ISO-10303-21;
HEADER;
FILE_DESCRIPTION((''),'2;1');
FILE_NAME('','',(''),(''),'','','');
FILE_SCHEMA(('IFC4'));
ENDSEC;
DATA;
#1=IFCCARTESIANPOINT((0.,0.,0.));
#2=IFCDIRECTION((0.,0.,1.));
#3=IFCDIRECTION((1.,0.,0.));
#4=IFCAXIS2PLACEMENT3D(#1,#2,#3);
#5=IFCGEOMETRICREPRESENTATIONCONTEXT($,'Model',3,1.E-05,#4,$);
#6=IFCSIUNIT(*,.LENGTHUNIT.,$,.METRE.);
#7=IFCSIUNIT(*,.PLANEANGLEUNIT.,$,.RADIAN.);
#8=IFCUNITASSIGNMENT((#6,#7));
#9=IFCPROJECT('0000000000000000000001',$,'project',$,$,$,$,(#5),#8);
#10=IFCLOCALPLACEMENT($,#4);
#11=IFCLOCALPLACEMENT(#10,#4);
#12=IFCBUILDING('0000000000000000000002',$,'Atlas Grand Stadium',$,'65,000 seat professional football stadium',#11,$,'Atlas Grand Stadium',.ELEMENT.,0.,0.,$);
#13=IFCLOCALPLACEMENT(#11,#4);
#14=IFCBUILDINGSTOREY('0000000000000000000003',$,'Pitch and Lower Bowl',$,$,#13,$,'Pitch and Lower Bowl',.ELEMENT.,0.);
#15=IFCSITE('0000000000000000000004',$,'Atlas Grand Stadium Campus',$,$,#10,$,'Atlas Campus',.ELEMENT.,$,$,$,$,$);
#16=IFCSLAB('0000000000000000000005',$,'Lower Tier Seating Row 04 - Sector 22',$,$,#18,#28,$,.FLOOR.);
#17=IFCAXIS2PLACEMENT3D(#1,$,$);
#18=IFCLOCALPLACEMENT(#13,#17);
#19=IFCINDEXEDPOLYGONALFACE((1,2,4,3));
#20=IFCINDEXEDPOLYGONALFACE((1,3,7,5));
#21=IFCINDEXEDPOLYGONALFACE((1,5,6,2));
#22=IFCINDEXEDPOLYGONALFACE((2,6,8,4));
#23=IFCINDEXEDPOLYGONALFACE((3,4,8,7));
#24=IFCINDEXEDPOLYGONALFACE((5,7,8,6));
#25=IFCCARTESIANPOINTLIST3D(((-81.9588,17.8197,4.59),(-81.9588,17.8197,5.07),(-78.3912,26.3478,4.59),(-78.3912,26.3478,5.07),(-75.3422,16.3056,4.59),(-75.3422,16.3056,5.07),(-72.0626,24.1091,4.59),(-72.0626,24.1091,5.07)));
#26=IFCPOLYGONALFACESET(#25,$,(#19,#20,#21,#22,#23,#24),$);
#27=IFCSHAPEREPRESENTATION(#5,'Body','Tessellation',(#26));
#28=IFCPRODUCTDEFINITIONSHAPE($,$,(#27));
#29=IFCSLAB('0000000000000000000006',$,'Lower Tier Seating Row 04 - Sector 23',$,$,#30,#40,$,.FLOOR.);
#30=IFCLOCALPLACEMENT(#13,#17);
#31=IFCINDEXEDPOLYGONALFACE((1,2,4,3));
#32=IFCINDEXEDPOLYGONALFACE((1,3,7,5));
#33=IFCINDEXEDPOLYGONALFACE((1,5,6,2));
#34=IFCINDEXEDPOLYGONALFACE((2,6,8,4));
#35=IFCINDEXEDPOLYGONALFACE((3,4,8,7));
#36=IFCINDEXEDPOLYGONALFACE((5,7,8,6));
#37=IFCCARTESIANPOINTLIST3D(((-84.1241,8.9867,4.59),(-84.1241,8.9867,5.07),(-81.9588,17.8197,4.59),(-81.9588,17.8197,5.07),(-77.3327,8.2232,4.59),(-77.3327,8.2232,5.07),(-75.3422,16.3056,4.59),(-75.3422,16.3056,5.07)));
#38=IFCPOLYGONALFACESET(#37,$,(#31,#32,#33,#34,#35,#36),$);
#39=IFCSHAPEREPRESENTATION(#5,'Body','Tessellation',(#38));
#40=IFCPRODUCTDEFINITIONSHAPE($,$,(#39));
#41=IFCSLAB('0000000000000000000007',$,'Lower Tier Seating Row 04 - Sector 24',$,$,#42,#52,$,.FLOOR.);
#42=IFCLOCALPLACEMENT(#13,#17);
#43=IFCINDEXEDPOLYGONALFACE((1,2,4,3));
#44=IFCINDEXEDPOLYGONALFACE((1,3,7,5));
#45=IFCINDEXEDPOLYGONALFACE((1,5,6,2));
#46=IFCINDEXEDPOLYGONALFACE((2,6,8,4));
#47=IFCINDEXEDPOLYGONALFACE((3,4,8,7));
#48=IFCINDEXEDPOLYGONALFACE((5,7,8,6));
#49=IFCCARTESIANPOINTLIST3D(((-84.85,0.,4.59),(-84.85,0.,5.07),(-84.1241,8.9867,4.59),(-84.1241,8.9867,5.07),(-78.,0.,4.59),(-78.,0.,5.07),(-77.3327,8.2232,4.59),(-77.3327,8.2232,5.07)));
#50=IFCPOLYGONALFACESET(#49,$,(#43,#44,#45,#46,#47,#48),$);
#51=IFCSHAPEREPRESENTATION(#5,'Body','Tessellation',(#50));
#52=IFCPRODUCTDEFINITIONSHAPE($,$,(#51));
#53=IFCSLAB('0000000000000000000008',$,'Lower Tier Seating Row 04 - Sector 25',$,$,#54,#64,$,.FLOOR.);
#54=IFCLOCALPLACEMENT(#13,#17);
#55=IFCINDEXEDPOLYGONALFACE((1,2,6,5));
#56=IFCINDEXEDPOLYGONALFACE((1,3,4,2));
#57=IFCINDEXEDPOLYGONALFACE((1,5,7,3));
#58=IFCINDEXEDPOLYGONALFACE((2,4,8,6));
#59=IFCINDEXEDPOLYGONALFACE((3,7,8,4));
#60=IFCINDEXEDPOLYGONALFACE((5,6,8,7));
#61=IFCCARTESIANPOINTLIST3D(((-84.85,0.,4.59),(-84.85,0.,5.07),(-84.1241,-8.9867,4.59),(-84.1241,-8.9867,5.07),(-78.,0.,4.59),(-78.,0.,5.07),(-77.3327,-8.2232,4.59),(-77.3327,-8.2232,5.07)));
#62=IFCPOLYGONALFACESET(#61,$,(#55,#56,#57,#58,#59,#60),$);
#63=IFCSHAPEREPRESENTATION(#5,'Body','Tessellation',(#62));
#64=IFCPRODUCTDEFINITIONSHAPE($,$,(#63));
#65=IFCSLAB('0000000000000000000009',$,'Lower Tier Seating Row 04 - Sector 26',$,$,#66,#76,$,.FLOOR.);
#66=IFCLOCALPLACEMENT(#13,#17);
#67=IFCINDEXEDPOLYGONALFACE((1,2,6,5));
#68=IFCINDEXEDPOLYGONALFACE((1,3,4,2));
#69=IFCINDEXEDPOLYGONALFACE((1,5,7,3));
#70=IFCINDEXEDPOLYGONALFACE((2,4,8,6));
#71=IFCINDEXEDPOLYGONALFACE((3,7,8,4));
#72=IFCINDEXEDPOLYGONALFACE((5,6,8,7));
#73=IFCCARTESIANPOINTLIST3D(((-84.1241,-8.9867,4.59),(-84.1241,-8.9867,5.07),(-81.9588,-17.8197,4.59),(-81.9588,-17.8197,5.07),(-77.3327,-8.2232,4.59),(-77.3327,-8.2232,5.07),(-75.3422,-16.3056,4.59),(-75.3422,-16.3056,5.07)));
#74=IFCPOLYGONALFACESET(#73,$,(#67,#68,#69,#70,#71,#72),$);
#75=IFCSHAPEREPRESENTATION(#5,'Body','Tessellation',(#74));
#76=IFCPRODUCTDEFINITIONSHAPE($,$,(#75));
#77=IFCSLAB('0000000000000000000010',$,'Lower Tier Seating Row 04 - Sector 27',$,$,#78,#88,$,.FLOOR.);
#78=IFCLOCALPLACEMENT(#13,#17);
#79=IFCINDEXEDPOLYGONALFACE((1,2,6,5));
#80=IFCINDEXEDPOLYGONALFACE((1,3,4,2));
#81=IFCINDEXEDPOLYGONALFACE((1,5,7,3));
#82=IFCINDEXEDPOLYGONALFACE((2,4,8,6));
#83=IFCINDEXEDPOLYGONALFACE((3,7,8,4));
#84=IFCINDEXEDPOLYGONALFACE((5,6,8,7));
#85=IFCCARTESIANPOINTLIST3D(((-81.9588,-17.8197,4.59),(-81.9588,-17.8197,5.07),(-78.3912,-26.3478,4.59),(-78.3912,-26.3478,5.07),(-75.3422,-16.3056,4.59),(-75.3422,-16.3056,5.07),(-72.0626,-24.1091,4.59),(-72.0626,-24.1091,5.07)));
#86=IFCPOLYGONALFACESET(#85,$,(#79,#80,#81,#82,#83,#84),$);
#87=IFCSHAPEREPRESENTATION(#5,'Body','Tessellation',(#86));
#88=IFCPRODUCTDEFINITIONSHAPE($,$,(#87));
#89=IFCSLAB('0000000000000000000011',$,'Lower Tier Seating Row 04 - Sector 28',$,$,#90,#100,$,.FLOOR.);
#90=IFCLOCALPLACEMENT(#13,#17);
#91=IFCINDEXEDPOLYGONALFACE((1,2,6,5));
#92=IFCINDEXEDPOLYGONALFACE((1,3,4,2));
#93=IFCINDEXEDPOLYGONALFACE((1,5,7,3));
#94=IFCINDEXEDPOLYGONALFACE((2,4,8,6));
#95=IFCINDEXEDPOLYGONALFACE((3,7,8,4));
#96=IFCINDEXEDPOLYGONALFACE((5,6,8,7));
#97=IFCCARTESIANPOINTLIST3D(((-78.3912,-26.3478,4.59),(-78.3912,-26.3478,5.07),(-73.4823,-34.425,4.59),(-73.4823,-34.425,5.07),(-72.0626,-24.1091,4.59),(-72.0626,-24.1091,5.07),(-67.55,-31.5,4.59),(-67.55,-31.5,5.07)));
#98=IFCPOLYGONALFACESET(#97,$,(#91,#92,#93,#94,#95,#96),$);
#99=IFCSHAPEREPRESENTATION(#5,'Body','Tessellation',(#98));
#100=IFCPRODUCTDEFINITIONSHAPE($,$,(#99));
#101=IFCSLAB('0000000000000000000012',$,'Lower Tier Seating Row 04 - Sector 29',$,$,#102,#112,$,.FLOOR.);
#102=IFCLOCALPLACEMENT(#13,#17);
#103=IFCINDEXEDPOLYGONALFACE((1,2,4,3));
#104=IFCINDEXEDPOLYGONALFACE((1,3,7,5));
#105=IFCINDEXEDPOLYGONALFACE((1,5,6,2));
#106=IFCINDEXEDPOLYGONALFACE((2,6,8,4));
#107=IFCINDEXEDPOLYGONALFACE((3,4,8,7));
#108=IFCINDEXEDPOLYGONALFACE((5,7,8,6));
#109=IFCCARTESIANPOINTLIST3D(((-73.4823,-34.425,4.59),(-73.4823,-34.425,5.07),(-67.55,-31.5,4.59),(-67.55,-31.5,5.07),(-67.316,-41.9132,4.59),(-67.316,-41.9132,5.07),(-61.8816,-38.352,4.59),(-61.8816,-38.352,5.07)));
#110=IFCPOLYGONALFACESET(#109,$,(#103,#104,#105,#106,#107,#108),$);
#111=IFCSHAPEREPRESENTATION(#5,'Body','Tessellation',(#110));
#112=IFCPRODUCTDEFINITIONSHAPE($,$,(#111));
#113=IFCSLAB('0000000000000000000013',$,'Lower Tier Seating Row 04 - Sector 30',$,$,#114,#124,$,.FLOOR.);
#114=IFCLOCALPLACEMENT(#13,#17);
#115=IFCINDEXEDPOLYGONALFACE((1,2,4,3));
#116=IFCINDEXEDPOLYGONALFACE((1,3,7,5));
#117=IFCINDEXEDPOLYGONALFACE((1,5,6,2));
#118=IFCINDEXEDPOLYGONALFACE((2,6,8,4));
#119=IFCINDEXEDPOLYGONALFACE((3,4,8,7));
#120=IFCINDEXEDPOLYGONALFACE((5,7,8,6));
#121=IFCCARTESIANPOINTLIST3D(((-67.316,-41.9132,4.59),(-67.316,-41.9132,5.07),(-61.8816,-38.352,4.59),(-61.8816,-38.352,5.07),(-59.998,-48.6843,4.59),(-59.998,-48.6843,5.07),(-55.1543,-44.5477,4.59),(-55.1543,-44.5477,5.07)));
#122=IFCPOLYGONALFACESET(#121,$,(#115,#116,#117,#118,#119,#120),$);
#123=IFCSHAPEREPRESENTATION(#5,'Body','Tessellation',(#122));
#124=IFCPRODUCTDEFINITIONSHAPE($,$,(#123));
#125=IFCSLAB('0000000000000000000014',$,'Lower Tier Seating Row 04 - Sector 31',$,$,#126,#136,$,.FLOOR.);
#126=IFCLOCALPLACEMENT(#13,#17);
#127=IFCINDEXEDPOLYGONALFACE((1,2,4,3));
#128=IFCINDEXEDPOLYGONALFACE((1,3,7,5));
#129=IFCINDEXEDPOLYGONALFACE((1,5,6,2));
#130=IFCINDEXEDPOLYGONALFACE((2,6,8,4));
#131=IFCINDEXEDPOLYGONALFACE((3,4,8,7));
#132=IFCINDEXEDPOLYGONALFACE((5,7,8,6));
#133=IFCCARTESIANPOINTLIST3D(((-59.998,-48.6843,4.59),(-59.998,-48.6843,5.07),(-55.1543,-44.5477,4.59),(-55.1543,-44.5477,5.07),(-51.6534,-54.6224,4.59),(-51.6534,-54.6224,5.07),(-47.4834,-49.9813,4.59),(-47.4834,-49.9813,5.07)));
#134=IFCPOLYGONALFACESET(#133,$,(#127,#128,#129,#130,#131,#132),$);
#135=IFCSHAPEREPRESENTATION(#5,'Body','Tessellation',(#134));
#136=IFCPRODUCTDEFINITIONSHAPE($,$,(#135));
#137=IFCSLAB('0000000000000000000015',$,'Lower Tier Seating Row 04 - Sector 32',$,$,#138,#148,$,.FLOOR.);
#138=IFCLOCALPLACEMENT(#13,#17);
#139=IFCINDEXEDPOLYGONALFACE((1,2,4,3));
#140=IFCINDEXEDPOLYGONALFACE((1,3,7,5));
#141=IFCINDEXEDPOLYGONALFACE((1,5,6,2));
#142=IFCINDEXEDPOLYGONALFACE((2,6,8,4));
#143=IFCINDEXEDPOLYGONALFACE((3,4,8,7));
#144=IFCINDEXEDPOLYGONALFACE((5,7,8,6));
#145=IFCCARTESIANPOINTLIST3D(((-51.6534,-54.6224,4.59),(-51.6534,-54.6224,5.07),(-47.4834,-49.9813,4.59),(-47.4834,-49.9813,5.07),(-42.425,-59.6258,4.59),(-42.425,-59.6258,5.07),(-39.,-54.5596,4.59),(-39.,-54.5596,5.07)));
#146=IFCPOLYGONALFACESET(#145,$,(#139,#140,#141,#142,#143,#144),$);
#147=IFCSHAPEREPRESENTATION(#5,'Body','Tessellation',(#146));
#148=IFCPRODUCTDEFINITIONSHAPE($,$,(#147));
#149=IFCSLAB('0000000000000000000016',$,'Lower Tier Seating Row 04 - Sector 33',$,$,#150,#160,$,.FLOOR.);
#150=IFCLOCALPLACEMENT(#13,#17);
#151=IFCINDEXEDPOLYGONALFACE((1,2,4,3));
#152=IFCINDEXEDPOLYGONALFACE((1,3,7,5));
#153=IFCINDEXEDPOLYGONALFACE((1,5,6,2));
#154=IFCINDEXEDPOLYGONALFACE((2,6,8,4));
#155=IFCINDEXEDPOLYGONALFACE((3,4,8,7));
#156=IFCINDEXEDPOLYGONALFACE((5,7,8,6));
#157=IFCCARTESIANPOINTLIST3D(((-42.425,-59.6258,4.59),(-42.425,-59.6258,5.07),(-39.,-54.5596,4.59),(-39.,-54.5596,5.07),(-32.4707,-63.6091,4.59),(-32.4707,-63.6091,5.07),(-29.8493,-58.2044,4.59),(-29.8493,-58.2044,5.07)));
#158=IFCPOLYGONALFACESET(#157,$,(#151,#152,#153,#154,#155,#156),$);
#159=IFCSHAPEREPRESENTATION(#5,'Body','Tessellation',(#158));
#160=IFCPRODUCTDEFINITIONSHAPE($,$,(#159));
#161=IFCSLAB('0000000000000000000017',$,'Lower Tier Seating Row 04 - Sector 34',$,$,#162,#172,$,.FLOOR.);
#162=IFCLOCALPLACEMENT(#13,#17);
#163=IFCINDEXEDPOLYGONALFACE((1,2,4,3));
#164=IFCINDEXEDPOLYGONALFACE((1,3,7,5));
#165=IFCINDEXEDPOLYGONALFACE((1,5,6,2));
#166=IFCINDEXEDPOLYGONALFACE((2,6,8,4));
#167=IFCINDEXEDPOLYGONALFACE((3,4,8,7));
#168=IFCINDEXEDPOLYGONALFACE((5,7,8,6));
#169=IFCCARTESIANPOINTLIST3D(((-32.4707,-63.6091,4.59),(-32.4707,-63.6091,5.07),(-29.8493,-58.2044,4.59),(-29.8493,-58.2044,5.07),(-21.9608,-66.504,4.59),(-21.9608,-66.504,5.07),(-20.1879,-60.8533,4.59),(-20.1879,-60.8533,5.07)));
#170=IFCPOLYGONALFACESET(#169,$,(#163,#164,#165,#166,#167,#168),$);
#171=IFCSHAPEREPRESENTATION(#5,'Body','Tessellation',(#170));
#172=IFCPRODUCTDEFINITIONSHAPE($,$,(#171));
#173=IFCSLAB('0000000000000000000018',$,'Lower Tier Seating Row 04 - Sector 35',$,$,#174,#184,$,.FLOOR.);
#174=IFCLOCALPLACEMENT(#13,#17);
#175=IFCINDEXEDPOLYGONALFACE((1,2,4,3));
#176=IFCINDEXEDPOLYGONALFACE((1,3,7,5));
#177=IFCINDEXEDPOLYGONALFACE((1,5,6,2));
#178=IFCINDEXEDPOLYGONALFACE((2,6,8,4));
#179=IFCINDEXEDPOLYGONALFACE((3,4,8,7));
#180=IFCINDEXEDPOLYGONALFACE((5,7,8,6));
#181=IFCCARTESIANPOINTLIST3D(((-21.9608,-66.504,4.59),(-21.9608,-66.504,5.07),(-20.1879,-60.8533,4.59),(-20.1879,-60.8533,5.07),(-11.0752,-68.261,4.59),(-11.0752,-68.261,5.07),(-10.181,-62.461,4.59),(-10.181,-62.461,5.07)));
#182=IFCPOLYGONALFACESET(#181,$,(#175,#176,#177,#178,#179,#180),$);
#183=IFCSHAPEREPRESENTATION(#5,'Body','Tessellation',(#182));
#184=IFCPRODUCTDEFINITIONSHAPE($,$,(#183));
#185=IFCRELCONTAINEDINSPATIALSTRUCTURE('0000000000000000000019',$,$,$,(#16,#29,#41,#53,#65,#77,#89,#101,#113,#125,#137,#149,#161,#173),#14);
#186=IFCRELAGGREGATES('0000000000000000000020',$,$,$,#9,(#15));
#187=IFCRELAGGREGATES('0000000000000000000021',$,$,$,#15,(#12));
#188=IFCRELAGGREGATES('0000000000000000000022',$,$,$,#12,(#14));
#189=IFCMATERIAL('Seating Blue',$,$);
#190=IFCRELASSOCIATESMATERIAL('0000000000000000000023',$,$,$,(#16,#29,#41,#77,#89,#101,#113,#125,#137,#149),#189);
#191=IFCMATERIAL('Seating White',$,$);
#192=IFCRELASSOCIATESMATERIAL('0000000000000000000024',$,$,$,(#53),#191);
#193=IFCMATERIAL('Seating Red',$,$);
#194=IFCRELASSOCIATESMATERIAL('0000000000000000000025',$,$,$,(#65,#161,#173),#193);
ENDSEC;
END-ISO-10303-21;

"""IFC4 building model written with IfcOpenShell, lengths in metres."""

from ifc_helpers import new_model, si_unit, frame, origin_with_axes, place, context, project, spatial, polyline, outline, extrude, material, element, save


model = new_model("IFC4")

# Units and contexts
model_context = context("Model", 3, precision=1e-05, world=origin_with_axes())
ifc_project = project(units=[si_unit("LENGTHUNIT", "METRE"), si_unit("PLANEANGLEUNIT", "RADIAN")], contexts=[model_context])

# Site, building, storey
site_placement = place(None, origin_with_axes())
site = spatial("IfcSite", under=ifc_project, at=site_placement, Name="Atlas Grand Stadium Campus", LongName="Atlas Campus", CompositionType="ELEMENT")
building_placement = place(site_placement, origin_with_axes())
building = spatial("IfcBuilding", under=site, at=building_placement, Name="Atlas Grand Stadium", ObjectType="65,000 seat professional football stadium", LongName="Atlas Grand Stadium", CompositionType="ELEMENT", ElevationOfRefHeight=0.0, ElevationOfTerrain=0.0)
storey_placement = place(building_placement, origin_with_axes())
storey = spatial("IfcBuildingStorey", under=building, at=storey_placement, Name="Pitch and Lower Bowl", LongName="Pitch and Lower Bowl", CompositionType="ELEMENT", Elevation=0.0)

# Slabs
ifc_material_1 = material(Name="Seating Blue")
slab_1_placement = place(storey_placement, frame((0.0, 0.0, 4.59), z_axis=(0.0, 0.0, 1.0), x_axis=(1.0, 0.0, 0.0)))
element("IfcSlab", 1, at=slab_1_placement, inside=storey, material=ifc_material_1, Name="Lower Tier Seating Row 04 - Sector 22", PredefinedType="FLOOR", context=model_context, shape_type="SweptSolid", body=[
    extrude(outline(polyline([(-78.3912, 26.3478), (-81.9588, 17.8197), (-75.3422, 16.3056), (-72.0626, 24.1091), (-78.3912, 26.3478)])), origin_with_axes(), (0.0, 0.0, 1.0), 0.48),
])
slab_2_placement = place(storey_placement, frame((0.0, 0.0, 4.59), z_axis=(0.0, 0.0, 1.0), x_axis=(1.0, 0.0, 0.0)))
element("IfcSlab", 2, at=slab_2_placement, inside=storey, material=ifc_material_1, Name="Lower Tier Seating Row 04 - Sector 23", PredefinedType="FLOOR", context=model_context, shape_type="SweptSolid", body=[
    extrude(outline(polyline([(-81.9588, 17.8197), (-84.1241, 8.9867), (-77.3327, 8.2232), (-75.3422, 16.3056), (-81.9588, 17.8197)])), origin_with_axes(), (0.0, 0.0, 1.0), 0.48),
])
slab_3_placement = place(storey_placement, frame((0.0, 0.0, 4.59), z_axis=(0.0, 0.0, 1.0), x_axis=(1.0, 0.0, 0.0)))
element("IfcSlab", 3, at=slab_3_placement, inside=storey, material=ifc_material_1, Name="Lower Tier Seating Row 04 - Sector 24", PredefinedType="FLOOR", context=model_context, shape_type="SweptSolid", body=[
    extrude(outline(polyline([(-84.1241, 8.9867), (-84.85, 0.0), (-78.0, 0.0), (-77.3327, 8.2232), (-84.1241, 8.9867)])), origin_with_axes(), (0.0, 0.0, 1.0), 0.48),
])
ifc_material_2 = material(Name="Seating White")
slab_4_placement = place(storey_placement, frame((0.0, 0.0, 4.59), z_axis=(0.0, 0.0, 1.0), x_axis=(1.0, 0.0, 0.0)))
element("IfcSlab", 4, at=slab_4_placement, inside=storey, material=ifc_material_2, Name="Lower Tier Seating Row 04 - Sector 25", PredefinedType="FLOOR", context=model_context, shape_type="SweptSolid", body=[
    extrude(outline(polyline([(-84.85, 0.0), (-84.1241, -8.9867), (-77.3327, -8.2232), (-78.0, 0.0), (-84.85, 0.0)])), origin_with_axes(), (0.0, 0.0, 1.0), 0.48),
])
ifc_material_3 = material(Name="Seating Red")
slab_5_placement = place(storey_placement, frame((0.0, 0.0, 4.59), z_axis=(0.0, 0.0, 1.0), x_axis=(1.0, 0.0, 0.0)))
element("IfcSlab", 5, at=slab_5_placement, inside=storey, material=ifc_material_3, Name="Lower Tier Seating Row 04 - Sector 26", PredefinedType="FLOOR", context=model_context, shape_type="SweptSolid", body=[
    extrude(outline(polyline([(-84.1241, -8.9867), (-81.9588, -17.8197), (-75.3422, -16.3056), (-77.3327, -8.2232), (-84.1241, -8.9867)])), origin_with_axes(), (0.0, 0.0, 1.0), 0.48),
])
slab_6_placement = place(storey_placement, frame((0.0, 0.0, 4.59), z_axis=(0.0, 0.0, 1.0), x_axis=(1.0, 0.0, 0.0)))
element("IfcSlab", 6, at=slab_6_placement, inside=storey, material=ifc_material_1, Name="Lower Tier Seating Row 04 - Sector 27", PredefinedType="FLOOR", context=model_context, shape_type="SweptSolid", body=[
    extrude(outline(polyline([(-81.9588, -17.8197), (-78.3912, -26.3478), (-72.0626, -24.1091), (-75.3422, -16.3056), (-81.9588, -17.8197)])), origin_with_axes(), (0.0, 0.0, 1.0), 0.48),
])
slab_7_placement = place(storey_placement, frame((0.0, 0.0, 4.59), z_axis=(0.0, 0.0, 1.0), x_axis=(1.0, 0.0, 0.0)))
element("IfcSlab", 7, at=slab_7_placement, inside=storey, material=ifc_material_1, Name="Lower Tier Seating Row 04 - Sector 28", PredefinedType="FLOOR", context=model_context, shape_type="SweptSolid", body=[
    extrude(outline(polyline([(-78.3912, -26.3478), (-73.4823, -34.425), (-67.55, -31.5), (-72.0626, -24.1091), (-78.3912, -26.3478)])), origin_with_axes(), (0.0, 0.0, 1.0), 0.48),
])
slab_8_placement = place(storey_placement, frame((0.0, 0.0, 4.59), z_axis=(0.0, 0.0, 1.0), x_axis=(1.0, 0.0, 0.0)))
element("IfcSlab", 8, at=slab_8_placement, inside=storey, material=ifc_material_1, Name="Lower Tier Seating Row 04 - Sector 29", PredefinedType="FLOOR", context=model_context, shape_type="SweptSolid", body=[
    extrude(outline(polyline([(-73.4823, -34.425), (-67.316, -41.9132), (-61.8816, -38.352), (-67.55, -31.5), (-73.4823, -34.425)])), origin_with_axes(), (0.0, 0.0, 1.0), 0.48),
])
slab_9_placement = place(storey_placement, frame((0.0, 0.0, 4.59), z_axis=(0.0, 0.0, 1.0), x_axis=(1.0, 0.0, 0.0)))
element("IfcSlab", 9, at=slab_9_placement, inside=storey, material=ifc_material_1, Name="Lower Tier Seating Row 04 - Sector 30", PredefinedType="FLOOR", context=model_context, shape_type="SweptSolid", body=[
    extrude(outline(polyline([(-67.316, -41.9132), (-59.998, -48.6843), (-55.1543, -44.5477), (-61.8816, -38.352), (-67.316, -41.9132)])), origin_with_axes(), (0.0, 0.0, 1.0), 0.48),
])
slab_10_placement = place(storey_placement, frame((0.0, 0.0, 4.59), z_axis=(0.0, 0.0, 1.0), x_axis=(1.0, 0.0, 0.0)))
element("IfcSlab", 10, at=slab_10_placement, inside=storey, material=ifc_material_1, Name="Lower Tier Seating Row 04 - Sector 31", PredefinedType="FLOOR", context=model_context, shape_type="SweptSolid", body=[
    extrude(outline(polyline([(-59.998, -48.6843), (-51.6534, -54.6224), (-47.4834, -49.9813), (-55.1543, -44.5477), (-59.998, -48.6843)])), origin_with_axes(), (0.0, 0.0, 1.0), 0.48),
])
slab_11_placement = place(storey_placement, frame((0.0, 0.0, 4.59), z_axis=(0.0, 0.0, 1.0), x_axis=(1.0, 0.0, 0.0)))
element("IfcSlab", 11, at=slab_11_placement, inside=storey, material=ifc_material_1, Name="Lower Tier Seating Row 04 - Sector 32", PredefinedType="FLOOR", context=model_context, shape_type="SweptSolid", body=[
    extrude(outline(polyline([(-51.6534, -54.6224), (-42.425, -59.6258), (-39.0, -54.5596), (-47.4834, -49.9813), (-51.6534, -54.6224)])), origin_with_axes(), (0.0, 0.0, 1.0), 0.48),
])
slab_12_placement = place(storey_placement, frame((0.0, 0.0, 4.59), z_axis=(0.0, 0.0, 1.0), x_axis=(1.0, 0.0, 0.0)))
element("IfcSlab", 12, at=slab_12_placement, inside=storey, material=ifc_material_1, Name="Lower Tier Seating Row 04 - Sector 33", PredefinedType="FLOOR", context=model_context, shape_type="SweptSolid", body=[
    extrude(outline(polyline([(-42.425, -59.6258), (-32.4707, -63.6091), (-29.8493, -58.2044), (-39.0, -54.5596), (-42.425, -59.6258)])), origin_with_axes(), (0.0, 0.0, 1.0), 0.48),
])
slab_13_placement = place(storey_placement, frame((0.0, 0.0, 4.59), z_axis=(0.0, 0.0, 1.0), x_axis=(1.0, 0.0, 0.0)))
element("IfcSlab", 13, at=slab_13_placement, inside=storey, material=ifc_material_3, Name="Lower Tier Seating Row 04 - Sector 34", PredefinedType="FLOOR", context=model_context, shape_type="SweptSolid", body=[
    extrude(outline(polyline([(-32.4707, -63.6091), (-21.9608, -66.504), (-20.1879, -60.8533), (-29.8493, -58.2044), (-32.4707, -63.6091)])), origin_with_axes(), (0.0, 0.0, 1.0), 0.48),
])
slab_14_placement = place(storey_placement, frame((0.0, 0.0, 4.59), z_axis=(0.0, 0.0, 1.0), x_axis=(1.0, 0.0, 0.0)))
element("IfcSlab", 14, at=slab_14_placement, inside=storey, material=ifc_material_3, Name="Lower Tier Seating Row 04 - Sector 35", PredefinedType="FLOOR", context=model_context, shape_type="SweptSolid", body=[
    extrude(outline(polyline([(-21.9608, -66.504), (-11.0752, -68.261), (-10.181, -62.461), (-20.1879, -60.8533), (-21.9608, -66.504)])), origin_with_axes(), (0.0, 0.0, 1.0), 0.48),
])

save(model, "model.ifc")
